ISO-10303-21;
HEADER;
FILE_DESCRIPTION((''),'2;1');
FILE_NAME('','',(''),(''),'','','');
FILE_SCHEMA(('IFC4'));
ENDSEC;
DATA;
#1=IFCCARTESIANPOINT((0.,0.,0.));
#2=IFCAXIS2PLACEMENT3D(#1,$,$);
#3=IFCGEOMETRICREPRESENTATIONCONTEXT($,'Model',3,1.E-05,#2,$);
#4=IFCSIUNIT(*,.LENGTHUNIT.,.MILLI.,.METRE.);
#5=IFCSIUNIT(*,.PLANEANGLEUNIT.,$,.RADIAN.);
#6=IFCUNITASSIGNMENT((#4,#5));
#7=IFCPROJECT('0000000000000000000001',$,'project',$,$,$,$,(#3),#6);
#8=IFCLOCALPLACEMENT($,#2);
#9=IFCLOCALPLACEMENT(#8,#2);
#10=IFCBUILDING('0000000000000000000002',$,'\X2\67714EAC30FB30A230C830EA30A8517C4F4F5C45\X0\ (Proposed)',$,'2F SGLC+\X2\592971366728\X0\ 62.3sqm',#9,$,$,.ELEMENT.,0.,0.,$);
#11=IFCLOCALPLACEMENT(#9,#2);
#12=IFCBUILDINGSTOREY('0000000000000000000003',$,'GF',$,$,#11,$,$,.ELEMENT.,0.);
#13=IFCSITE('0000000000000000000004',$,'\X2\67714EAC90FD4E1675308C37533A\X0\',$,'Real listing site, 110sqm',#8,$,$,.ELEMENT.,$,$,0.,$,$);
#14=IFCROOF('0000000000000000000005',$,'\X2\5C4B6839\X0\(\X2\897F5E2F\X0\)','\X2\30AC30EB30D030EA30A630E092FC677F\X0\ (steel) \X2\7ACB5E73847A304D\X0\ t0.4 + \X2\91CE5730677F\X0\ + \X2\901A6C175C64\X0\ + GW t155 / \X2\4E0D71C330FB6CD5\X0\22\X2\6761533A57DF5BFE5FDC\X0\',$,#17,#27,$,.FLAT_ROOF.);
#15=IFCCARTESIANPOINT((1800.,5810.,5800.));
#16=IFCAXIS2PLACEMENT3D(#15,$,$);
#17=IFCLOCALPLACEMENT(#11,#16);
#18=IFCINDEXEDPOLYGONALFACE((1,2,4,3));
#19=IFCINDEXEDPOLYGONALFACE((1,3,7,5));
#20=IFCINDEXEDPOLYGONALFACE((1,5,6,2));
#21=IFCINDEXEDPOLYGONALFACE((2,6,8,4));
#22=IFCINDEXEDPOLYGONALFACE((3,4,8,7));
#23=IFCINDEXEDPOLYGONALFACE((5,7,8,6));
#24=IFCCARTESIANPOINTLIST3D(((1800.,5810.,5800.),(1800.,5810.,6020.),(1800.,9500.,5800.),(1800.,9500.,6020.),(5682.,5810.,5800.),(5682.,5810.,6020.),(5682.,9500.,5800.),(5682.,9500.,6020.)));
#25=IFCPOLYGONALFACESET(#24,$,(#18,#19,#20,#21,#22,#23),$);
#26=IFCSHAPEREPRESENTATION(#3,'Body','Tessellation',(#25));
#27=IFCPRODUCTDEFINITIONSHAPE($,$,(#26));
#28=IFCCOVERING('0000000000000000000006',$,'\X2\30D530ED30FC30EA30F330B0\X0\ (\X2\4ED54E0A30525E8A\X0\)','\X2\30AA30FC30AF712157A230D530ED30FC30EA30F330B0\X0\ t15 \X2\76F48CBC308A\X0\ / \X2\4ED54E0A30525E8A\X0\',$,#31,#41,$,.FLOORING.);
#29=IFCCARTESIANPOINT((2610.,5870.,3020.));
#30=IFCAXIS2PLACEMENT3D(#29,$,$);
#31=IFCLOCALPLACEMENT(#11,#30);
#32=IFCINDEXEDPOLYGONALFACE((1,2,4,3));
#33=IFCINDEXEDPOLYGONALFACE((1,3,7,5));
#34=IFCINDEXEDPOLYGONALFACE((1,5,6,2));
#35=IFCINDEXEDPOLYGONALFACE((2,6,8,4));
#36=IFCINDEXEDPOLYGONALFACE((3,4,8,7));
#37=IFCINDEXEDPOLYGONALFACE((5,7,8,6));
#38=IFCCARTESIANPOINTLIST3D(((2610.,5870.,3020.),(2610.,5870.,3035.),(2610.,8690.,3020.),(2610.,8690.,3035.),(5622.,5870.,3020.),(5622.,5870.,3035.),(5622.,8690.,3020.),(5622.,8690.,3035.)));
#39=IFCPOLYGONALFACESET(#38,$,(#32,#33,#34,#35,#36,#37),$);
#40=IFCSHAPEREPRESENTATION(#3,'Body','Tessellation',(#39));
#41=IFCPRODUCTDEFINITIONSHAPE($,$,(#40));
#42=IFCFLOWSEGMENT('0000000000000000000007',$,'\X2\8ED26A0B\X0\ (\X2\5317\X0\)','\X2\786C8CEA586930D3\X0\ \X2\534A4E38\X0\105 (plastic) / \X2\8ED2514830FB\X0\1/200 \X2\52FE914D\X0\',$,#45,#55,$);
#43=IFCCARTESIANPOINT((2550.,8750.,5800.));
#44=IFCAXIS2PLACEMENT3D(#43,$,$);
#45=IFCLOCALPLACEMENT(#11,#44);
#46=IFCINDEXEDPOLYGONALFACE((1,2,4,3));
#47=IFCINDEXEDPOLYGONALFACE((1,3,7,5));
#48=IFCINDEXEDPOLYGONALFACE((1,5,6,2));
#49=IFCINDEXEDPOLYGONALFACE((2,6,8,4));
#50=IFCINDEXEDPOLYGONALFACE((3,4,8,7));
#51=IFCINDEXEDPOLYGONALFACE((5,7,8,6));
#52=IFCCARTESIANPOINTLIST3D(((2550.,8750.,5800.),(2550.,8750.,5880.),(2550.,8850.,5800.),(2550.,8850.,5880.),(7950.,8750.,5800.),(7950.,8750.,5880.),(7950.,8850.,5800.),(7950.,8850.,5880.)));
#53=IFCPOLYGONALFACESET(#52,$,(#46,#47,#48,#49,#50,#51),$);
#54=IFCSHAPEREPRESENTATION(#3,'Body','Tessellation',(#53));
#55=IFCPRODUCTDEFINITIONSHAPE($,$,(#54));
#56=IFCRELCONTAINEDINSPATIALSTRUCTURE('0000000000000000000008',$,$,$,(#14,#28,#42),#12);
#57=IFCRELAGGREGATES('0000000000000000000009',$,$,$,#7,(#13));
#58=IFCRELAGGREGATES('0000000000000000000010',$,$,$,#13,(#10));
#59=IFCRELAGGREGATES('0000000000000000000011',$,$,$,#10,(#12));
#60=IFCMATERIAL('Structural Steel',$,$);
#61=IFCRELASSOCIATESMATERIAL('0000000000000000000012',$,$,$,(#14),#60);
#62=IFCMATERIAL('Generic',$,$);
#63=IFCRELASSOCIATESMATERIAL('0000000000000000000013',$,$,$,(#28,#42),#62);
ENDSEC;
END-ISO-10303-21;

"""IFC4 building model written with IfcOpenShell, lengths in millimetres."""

from ifc_helpers import new_model, si_unit, frame, frame_2d, origin, place, context, project, spatial, rectangle, extrude, material, element, save


model = new_model("IFC4")

# Units and contexts
model_context = context("Model", 3, precision=1e-05, world=origin())
ifc_project = project(units=[si_unit("LENGTHUNIT", "METRE", prefix="MILLI"), si_unit("PLANEANGLEUNIT", "RADIAN")], contexts=[model_context])

# Site, building, storey
site_placement = place(None, origin())
site = spatial("IfcSite", under=ifc_project, at=site_placement, Name="東京都世田谷区", ObjectType="Real listing site, 110sqm", CompositionType="ELEMENT", RefElevation=0.0)
building_placement = place(site_placement, origin())
building = spatial("IfcBuilding", under=site, at=building_placement, Name="東京・アトリエ兼住居 (Proposed)", ObjectType="2F SGLC+天然木 62.3sqm", CompositionType="ELEMENT", ElevationOfRefHeight=0.0, ElevationOfTerrain=0.0)
storey_placement = place(building_placement, origin())
storey = spatial("IfcBuildingStorey", under=building, at=storey_placement, Name="GF", CompositionType="ELEMENT", Elevation=0.0)

# Roof
ifc_material_1 = material(Name="Structural Steel")
for number, where, name in (
    (1, (1800.0, 5810.0, 5800.0), "屋根(西帯)"),
):
    element("IfcRoof", number, at=place(storey_placement, frame(where)), inside=storey, material=ifc_material_1, Name=name, Description="ガルバリウム鋼板 (steel) 立平葺き t0.4 + 野地板 + 通気層 + GW t155 / 不燃・法22条区域対応", PredefinedType="FLAT_ROOF", context=model_context, shape_type="SweptSolid", body=[
        extrude(rectangle(XDim=3882.0, YDim=3690.0, at=frame_2d((1941.0, 1845.0))), frame((1800.0, 5810.0, 5800.0)), (0.0, 0.0, 1.0), 220.0),
    ])

# Covering
ifc_material_2 = material(Name="Generic")
covering_placement = place(storey_placement, frame((2610.0, 5870.0, 3020.0)))
element("IfcCovering", 2, at=covering_placement, inside=storey, material=ifc_material_2, Name="フローリング (仕上げ床)", Description="オーク無垢フローリング t15 直貼り / 仕上げ床", PredefinedType="FLOORING", context=model_context, shape_type="SweptSolid", body=[
    extrude(rectangle(XDim=3012.0, YDim=2820.0, at=frame_2d((1506.0, 1410.0))), frame((2610.0, 5870.0, 3020.0)), (0.0, 0.0, 1.0), 15.0),
])

# Flow segment
flow_segment_placement = place(storey_placement, frame((2550.0, 8750.0, 5800.0)))
element("IfcFlowSegment", 3, at=flow_segment_placement, inside=storey, material=ifc_material_2, Name="軒樋 (北)", Description="硬質塩ビ 半丸105 (plastic) / 軒先・1/200 勾配", context=model_context, shape_type="SweptSolid", body=[
    extrude(rectangle(XDim=5400.0, YDim=100.0, at=frame_2d((2700.0, 50.0))), frame((2550.0, 8750.0, 5800.0)), (0.0, 0.0, 1.0), 80.0),
])

save(model, "model.ifc")
